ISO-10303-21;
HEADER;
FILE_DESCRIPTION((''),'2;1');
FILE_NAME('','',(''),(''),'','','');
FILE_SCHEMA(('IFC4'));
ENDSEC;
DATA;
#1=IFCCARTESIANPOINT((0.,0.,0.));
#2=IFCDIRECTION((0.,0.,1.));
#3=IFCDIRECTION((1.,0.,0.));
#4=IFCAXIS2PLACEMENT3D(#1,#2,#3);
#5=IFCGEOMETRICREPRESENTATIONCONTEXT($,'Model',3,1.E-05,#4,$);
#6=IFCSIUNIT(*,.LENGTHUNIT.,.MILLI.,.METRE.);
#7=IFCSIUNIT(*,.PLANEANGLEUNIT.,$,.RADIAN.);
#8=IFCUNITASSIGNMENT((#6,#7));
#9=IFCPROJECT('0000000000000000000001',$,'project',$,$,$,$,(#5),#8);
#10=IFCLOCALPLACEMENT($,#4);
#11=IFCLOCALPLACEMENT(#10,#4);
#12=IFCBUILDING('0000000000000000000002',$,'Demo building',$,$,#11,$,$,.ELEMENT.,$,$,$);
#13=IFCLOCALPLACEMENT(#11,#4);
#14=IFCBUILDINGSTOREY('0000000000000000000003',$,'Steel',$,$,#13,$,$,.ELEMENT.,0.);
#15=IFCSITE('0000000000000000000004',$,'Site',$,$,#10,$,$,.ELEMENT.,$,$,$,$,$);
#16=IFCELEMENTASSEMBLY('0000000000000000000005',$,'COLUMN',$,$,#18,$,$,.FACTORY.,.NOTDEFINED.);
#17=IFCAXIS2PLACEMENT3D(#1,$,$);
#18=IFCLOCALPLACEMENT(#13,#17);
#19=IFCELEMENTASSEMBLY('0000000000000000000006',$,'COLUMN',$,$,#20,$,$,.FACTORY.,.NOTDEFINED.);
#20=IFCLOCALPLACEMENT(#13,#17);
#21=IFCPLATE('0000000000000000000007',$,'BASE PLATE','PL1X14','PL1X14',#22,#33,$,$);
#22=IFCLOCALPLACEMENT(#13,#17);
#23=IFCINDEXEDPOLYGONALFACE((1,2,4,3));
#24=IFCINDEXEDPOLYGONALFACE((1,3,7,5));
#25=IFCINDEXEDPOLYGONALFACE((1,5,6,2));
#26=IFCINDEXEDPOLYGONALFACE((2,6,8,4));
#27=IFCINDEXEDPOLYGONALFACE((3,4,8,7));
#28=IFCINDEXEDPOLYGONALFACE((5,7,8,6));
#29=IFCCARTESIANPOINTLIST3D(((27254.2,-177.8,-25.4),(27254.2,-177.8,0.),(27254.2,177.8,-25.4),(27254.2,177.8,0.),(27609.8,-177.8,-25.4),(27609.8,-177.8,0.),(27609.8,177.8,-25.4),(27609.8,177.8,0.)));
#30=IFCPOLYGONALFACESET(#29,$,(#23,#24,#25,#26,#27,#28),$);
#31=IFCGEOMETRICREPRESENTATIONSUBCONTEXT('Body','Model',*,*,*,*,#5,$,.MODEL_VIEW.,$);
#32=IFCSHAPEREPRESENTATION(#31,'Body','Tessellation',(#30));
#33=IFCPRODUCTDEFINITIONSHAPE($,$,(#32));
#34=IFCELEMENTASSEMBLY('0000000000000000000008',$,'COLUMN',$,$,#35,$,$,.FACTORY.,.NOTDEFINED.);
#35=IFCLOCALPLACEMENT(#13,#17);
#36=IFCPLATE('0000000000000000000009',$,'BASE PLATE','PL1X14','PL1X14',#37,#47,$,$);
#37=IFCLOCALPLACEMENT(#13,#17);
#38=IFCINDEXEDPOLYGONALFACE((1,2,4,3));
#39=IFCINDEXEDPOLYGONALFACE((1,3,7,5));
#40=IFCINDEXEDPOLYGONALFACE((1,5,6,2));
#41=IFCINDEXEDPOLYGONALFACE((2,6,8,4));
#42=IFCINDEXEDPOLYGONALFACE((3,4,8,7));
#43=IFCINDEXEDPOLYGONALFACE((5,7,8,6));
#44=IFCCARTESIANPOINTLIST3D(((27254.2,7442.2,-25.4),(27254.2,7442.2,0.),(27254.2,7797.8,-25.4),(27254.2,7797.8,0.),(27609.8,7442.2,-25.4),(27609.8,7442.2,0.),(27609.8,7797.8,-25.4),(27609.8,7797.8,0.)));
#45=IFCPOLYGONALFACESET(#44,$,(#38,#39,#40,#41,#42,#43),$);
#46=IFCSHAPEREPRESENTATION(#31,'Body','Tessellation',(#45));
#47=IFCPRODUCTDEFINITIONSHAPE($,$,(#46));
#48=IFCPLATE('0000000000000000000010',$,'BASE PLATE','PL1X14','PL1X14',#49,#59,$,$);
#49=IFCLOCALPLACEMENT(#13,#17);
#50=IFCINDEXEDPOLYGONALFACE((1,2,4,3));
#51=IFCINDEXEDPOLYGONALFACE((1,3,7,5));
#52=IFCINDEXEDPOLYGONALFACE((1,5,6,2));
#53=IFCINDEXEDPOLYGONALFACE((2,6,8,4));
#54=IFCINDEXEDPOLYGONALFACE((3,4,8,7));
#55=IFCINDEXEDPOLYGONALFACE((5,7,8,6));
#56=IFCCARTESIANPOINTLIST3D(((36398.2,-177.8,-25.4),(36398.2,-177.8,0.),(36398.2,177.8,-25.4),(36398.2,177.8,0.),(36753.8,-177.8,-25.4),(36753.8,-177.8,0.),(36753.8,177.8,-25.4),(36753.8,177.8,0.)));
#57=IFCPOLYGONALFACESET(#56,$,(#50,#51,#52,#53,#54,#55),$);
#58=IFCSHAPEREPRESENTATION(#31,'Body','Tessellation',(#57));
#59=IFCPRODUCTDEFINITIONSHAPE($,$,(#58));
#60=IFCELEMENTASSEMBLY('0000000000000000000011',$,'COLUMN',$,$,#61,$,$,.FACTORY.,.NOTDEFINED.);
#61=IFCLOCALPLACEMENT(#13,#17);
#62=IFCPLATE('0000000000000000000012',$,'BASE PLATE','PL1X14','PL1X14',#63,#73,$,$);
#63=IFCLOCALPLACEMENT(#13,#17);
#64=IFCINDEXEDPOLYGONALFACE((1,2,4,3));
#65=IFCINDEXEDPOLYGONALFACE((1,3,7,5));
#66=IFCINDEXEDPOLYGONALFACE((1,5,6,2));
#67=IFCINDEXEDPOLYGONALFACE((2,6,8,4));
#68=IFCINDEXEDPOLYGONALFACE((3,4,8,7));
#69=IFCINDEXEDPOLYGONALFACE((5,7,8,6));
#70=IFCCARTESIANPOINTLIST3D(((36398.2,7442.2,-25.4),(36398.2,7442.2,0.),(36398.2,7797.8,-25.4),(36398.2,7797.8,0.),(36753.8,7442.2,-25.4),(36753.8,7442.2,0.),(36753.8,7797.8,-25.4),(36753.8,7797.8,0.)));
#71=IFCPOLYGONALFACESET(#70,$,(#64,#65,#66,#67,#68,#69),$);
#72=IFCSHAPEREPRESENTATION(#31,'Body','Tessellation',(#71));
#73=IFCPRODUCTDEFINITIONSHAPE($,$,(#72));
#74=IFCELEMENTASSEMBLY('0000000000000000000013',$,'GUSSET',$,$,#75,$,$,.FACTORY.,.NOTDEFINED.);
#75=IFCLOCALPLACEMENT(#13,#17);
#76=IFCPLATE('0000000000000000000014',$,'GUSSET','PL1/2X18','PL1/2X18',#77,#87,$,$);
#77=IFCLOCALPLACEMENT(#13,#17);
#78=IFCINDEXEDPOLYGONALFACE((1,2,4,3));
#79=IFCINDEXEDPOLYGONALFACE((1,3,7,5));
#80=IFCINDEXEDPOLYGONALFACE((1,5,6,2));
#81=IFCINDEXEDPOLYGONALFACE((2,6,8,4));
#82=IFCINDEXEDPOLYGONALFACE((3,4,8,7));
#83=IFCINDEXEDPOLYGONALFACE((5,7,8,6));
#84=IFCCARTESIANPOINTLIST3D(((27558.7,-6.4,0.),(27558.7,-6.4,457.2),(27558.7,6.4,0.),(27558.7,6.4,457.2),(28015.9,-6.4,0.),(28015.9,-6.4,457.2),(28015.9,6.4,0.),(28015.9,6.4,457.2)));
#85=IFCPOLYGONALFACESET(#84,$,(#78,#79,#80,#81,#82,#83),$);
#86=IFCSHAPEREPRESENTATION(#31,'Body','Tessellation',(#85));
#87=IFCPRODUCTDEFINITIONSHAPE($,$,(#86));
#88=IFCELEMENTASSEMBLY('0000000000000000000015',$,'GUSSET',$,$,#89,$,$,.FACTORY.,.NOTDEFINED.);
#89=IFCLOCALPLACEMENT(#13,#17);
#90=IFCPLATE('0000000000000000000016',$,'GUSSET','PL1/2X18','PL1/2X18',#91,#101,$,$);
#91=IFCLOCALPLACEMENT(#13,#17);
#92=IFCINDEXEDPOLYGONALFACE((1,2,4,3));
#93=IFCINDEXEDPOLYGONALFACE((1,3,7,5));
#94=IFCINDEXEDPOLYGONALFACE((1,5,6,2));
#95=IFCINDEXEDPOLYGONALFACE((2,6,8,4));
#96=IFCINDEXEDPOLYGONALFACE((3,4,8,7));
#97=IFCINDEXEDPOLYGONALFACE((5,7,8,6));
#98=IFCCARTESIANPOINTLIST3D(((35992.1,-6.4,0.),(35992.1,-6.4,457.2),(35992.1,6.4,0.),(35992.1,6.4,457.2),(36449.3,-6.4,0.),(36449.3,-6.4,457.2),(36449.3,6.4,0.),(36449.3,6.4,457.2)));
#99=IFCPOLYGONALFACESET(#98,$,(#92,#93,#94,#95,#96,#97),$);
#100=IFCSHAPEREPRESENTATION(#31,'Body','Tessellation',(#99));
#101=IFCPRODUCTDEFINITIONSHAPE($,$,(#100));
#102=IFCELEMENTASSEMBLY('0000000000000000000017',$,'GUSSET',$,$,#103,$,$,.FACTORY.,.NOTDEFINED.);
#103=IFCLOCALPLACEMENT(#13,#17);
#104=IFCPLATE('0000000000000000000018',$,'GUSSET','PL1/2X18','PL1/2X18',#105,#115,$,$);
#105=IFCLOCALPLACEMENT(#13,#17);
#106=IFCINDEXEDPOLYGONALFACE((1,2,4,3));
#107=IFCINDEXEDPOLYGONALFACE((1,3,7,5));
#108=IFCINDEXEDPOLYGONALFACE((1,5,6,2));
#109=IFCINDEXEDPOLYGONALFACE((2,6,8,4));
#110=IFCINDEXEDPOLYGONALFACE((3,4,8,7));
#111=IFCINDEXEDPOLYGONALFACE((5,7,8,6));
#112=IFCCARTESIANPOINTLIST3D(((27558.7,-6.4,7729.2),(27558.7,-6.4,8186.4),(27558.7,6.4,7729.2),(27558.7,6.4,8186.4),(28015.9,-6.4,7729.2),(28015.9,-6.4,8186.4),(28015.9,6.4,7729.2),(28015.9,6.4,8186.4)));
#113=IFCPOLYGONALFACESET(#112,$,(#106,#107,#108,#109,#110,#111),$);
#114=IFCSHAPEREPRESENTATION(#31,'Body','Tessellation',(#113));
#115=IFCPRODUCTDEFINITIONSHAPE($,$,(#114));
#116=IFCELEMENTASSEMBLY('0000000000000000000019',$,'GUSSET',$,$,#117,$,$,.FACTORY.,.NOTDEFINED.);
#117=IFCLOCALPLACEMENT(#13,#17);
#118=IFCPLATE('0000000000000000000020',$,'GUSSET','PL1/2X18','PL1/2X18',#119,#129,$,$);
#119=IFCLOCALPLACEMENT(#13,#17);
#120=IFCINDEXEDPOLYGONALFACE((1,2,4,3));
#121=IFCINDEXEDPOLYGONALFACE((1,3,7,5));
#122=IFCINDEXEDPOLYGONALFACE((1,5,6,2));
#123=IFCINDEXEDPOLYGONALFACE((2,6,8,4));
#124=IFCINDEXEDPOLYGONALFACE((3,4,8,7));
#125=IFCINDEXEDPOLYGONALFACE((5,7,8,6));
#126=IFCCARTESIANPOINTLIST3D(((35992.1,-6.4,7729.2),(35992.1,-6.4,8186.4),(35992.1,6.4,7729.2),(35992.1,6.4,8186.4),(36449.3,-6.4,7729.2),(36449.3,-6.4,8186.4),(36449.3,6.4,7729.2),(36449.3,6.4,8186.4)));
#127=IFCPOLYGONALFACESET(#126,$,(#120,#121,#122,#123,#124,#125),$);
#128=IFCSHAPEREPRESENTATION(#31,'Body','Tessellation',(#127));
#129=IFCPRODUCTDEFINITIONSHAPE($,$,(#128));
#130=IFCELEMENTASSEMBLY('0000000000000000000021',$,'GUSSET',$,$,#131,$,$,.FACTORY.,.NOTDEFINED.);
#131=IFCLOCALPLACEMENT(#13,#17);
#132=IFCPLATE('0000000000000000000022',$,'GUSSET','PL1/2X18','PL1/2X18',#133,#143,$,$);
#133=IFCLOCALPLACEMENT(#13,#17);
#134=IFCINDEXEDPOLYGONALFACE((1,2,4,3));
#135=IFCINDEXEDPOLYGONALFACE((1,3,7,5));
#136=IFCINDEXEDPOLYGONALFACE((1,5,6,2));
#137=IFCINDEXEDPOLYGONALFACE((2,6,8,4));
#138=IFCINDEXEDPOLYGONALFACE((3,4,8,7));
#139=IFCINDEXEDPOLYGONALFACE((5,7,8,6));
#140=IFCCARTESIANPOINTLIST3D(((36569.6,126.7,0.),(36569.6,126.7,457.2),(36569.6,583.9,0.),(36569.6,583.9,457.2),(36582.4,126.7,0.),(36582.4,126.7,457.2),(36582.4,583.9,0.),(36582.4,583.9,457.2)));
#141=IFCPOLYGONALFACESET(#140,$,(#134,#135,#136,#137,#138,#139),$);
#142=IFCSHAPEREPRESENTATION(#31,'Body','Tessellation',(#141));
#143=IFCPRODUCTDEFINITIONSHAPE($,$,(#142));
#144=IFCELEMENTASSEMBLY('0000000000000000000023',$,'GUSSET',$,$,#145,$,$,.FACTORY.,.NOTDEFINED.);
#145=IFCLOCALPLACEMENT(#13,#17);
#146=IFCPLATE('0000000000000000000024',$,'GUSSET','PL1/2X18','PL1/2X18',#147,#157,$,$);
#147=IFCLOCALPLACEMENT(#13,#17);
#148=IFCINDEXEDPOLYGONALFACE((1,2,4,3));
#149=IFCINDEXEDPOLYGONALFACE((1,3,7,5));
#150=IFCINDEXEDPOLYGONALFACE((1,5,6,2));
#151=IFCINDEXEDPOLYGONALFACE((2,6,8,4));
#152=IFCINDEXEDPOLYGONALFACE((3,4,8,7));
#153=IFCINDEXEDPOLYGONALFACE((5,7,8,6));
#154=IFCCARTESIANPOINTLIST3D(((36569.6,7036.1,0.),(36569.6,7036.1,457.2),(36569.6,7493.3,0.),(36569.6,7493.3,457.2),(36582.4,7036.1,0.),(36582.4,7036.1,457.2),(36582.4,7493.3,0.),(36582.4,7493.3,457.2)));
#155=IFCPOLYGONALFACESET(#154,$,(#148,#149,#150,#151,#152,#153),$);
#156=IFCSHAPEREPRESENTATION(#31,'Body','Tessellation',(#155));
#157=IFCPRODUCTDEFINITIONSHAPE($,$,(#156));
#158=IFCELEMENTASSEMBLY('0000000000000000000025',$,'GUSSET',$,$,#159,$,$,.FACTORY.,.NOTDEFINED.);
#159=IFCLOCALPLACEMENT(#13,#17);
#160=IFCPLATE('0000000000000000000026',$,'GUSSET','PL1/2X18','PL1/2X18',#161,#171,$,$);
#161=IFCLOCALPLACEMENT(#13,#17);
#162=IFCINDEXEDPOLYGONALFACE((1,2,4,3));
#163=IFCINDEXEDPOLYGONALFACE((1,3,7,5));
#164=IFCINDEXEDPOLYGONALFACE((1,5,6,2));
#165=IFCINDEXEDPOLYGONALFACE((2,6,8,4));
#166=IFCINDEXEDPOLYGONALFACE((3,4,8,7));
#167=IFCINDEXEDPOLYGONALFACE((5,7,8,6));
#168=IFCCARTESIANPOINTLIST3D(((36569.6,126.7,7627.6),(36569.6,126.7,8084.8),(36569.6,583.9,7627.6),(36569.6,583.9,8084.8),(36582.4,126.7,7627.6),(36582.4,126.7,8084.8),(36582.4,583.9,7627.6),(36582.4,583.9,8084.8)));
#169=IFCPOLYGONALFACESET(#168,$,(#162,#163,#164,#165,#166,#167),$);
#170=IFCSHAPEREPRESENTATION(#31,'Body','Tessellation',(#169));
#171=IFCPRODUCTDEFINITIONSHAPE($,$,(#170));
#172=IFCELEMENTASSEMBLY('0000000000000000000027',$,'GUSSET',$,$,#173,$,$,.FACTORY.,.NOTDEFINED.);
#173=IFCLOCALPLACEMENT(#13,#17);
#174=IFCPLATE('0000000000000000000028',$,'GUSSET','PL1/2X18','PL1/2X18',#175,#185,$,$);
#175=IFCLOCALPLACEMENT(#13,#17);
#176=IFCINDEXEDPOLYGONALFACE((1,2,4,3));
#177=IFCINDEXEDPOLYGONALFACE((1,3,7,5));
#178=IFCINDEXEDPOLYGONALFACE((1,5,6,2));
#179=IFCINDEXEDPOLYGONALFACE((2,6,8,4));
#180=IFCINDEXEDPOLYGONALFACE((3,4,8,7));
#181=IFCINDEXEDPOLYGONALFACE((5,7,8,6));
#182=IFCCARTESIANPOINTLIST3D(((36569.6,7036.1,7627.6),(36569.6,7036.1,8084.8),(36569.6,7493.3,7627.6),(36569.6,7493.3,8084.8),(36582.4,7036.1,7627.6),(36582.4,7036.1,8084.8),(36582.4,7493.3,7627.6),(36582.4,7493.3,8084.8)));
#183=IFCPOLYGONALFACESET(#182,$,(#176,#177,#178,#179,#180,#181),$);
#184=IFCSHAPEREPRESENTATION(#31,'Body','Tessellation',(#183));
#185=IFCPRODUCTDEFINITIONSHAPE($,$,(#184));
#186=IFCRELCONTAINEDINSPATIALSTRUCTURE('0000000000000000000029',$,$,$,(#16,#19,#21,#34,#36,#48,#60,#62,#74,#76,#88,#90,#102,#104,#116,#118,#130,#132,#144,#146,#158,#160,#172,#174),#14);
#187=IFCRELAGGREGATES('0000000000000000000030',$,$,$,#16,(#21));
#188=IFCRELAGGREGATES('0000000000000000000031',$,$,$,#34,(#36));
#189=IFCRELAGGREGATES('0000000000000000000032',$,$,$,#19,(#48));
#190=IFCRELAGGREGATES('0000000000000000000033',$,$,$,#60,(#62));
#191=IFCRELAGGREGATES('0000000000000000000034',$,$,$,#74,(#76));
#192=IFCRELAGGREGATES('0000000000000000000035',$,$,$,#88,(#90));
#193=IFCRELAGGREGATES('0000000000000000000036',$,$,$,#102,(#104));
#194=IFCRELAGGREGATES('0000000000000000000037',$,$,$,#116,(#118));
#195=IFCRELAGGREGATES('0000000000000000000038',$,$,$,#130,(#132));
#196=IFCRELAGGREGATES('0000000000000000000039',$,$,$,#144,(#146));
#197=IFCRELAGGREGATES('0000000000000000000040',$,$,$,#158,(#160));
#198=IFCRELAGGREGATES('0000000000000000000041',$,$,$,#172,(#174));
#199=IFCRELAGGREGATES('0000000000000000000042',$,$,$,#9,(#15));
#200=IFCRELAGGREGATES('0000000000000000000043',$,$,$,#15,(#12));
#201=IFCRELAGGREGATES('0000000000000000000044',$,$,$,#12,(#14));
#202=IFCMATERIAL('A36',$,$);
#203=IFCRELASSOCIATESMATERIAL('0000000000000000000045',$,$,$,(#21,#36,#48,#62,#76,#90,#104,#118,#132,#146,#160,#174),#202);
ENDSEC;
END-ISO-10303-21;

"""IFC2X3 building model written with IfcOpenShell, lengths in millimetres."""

from ifc_helpers import new_model, si_unit, frame, frame_2d, origin, origin_with_axes, place, context, subcontext, project, spatial, rectangle, extrude, material, element, aggregate, save


model = new_model("IFC2X3")

# Units and contexts
model_context = context("Model", 3, precision=1e-05, world=origin_with_axes())
body_context = subcontext(model_context, "Body", "Model", "MODEL_VIEW")
ifc_project = project(units=[si_unit("LENGTHUNIT", "METRE", prefix="MILLI"), si_unit("PLANEANGLEUNIT", "RADIAN")], contexts=[model_context])

# Site, building, storey
site_placement = place(None, origin_with_axes())
site = spatial("IfcSite", under=ifc_project, at=site_placement, Name="Site", CompositionType="ELEMENT")
building_placement = place(site_placement, origin_with_axes())
building = spatial("IfcBuilding", under=site, at=building_placement, Name="Demo building", CompositionType="ELEMENT")
placement = place(building_placement, origin_with_axes())
storey = spatial("IfcBuildingStorey", under=building, at=placement, Name="Steel", CompositionType="ELEMENT", Elevation=0.0)

# Element assemblies
assembly_1 = element("IfcElementAssembly", 1, at=placement, inside=storey, Name="COLUMN", AssemblyPlace="FACTORY", PredefinedType="NOTDEFINED")
assembly_2 = element("IfcElementAssembly", 2, at=placement, inside=storey, Name="COLUMN", AssemblyPlace="FACTORY", PredefinedType="NOTDEFINED")

# Plate
ifc_material_1 = material(Name="A36")
plate_1_placement = place(placement, frame((27254.2, -177.8, -25.4), z_axis=(0.0, 0.0, 1.0), x_axis=(1.0, 0.0, 0.0)))
plate_1 = element("IfcPlate", 3, at=plate_1_placement, inside=storey, material=ifc_material_1, Name="BASE PLATE", Description="PL1X14", ObjectType="PL1X14", context=body_context, shape_type="SweptSolid", body=[
    extrude(rectangle(XDim=355.6, YDim=355.6, at=frame_2d((177.8, 177.8))), origin(), (0.0, 0.0, 1.0), 25.4),
])
aggregate(assembly_1, [plate_1])

# Element assembly, plate
assembly_3 = element("IfcElementAssembly", 4, at=placement, inside=storey, Name="COLUMN", AssemblyPlace="FACTORY", PredefinedType="NOTDEFINED")
plate_2_placement = place(placement, frame((27254.2, 7442.2, -25.4), z_axis=(0.0, 0.0, 1.0), x_axis=(1.0, 0.0, 0.0)))
plate_2 = element("IfcPlate", 5, at=plate_2_placement, inside=storey, material=ifc_material_1, Name="BASE PLATE", Description="PL1X14", ObjectType="PL1X14", context=body_context, shape_type="SweptSolid", body=[
    extrude(rectangle(XDim=355.6, YDim=355.6, at=frame_2d((177.8, 177.8))), origin(), (0.0, 0.0, 1.0), 25.4),
])
aggregate(assembly_3, [plate_2])

# Plate
plate_3_placement = place(placement, frame((36398.2, -177.8, -25.4), z_axis=(0.0, 0.0, 1.0), x_axis=(1.0, 0.0, 0.0)))
plate_3 = element("IfcPlate", 6, at=plate_3_placement, inside=storey, material=ifc_material_1, Name="BASE PLATE", Description="PL1X14", ObjectType="PL1X14", context=body_context, shape_type="SweptSolid", body=[
    extrude(rectangle(XDim=355.6, YDim=355.6, at=frame_2d((177.8, 177.8))), origin(), (0.0, 0.0, 1.0), 25.4),
])
aggregate(assembly_2, [plate_3])

# Element assemblies, plates
assembly_4 = element("IfcElementAssembly", 7, at=placement, inside=storey, Name="COLUMN", AssemblyPlace="FACTORY", PredefinedType="NOTDEFINED")
plate_4_placement = place(placement, frame((36398.2, 7442.2, -25.4), z_axis=(0.0, 0.0, 1.0), x_axis=(1.0, 0.0, 0.0)))
plate_4 = element("IfcPlate", 8, at=plate_4_placement, inside=storey, material=ifc_material_1, Name="BASE PLATE", Description="PL1X14", ObjectType="PL1X14", context=body_context, shape_type="SweptSolid", body=[
    extrude(rectangle(XDim=355.6, YDim=355.6, at=frame_2d((177.8, 177.8))), origin(), (0.0, 0.0, 1.0), 25.4),
])
aggregate(assembly_4, [plate_4])
assembly_5 = element("IfcElementAssembly", 9, at=placement, inside=storey, Name="GUSSET", AssemblyPlace="FACTORY", PredefinedType="NOTDEFINED")
plate_5_placement = place(placement, frame((27558.7, 6.3, 0.0), z_axis=(0.0, -1.0, 0.0), x_axis=(1.0, 0.0, 0.0)))
plate_5 = element("IfcPlate", 10, at=plate_5_placement, inside=storey, material=ifc_material_1, Name="GUSSET", Description="PL1/2X18", ObjectType="PL1/2X18", context=body_context, shape_type="SweptSolid", body=[
    extrude(rectangle(XDim=457.2, YDim=457.2, at=frame_2d((228.6, 228.6))), origin(), (0.0, 0.0, 1.0), 12.7),
])
aggregate(assembly_5, [plate_5])
assembly_6 = element("IfcElementAssembly", 11, at=placement, inside=storey, Name="GUSSET", AssemblyPlace="FACTORY", PredefinedType="NOTDEFINED")
plate_6_placement = place(placement, frame((35992.1, 6.3, 0.0), z_axis=(0.0, -1.0, 0.0), x_axis=(1.0, 0.0, 0.0)))
plate_6 = element("IfcPlate", 12, at=plate_6_placement, inside=storey, material=ifc_material_1, Name="GUSSET", Description="PL1/2X18", ObjectType="PL1/2X18", context=body_context, shape_type="SweptSolid", body=[
    extrude(rectangle(XDim=457.2, YDim=457.2, at=frame_2d((228.6, 228.6))), origin(), (0.0, 0.0, 1.0), 12.7),
])
aggregate(assembly_6, [plate_6])
assembly_7 = element("IfcElementAssembly", 13, at=placement, inside=storey, Name="GUSSET", AssemblyPlace="FACTORY", PredefinedType="NOTDEFINED")
plate_7_placement = place(placement, frame((27558.7, 6.3, 7729.2), z_axis=(0.0, -1.0, 0.0), x_axis=(1.0, 0.0, 0.0)))
plate_7 = element("IfcPlate", 14, at=plate_7_placement, inside=storey, material=ifc_material_1, Name="GUSSET", Description="PL1/2X18", ObjectType="PL1/2X18", context=body_context, shape_type="SweptSolid", body=[
    extrude(rectangle(XDim=457.2, YDim=457.2, at=frame_2d((228.6, 228.6))), origin(), (0.0, 0.0, 1.0), 12.7),
])
aggregate(assembly_7, [plate_7])
assembly_8 = element("IfcElementAssembly", 15, at=placement, inside=storey, Name="GUSSET", AssemblyPlace="FACTORY", PredefinedType="NOTDEFINED")
plate_8_placement = place(placement, frame((35992.1, 6.3, 7729.2), z_axis=(0.0, -1.0, 0.0), x_axis=(1.0, 0.0, 0.0)))
plate_8 = element("IfcPlate", 16, at=plate_8_placement, inside=storey, material=ifc_material_1, Name="GUSSET", Description="PL1/2X18", ObjectType="PL1/2X18", context=body_context, shape_type="SweptSolid", body=[
    extrude(rectangle(XDim=457.2, YDim=457.2, at=frame_2d((228.6, 228.6))), origin(), (0.0, 0.0, 1.0), 12.7),
])
aggregate(assembly_8, [plate_8])
assembly_9 = element("IfcElementAssembly", 17, at=placement, inside=storey, Name="GUSSET", AssemblyPlace="FACTORY", PredefinedType="NOTDEFINED")
plate_9_placement = place(placement, frame((36569.7, 126.7, 0.0), z_axis=(1.0, 0.0, 0.0), x_axis=(0.0, 1.0, 0.0)))
plate_9 = element("IfcPlate", 18, at=plate_9_placement, inside=storey, material=ifc_material_1, Name="GUSSET", Description="PL1/2X18", ObjectType="PL1/2X18", context=body_context, shape_type="SweptSolid", body=[
    extrude(rectangle(XDim=457.2, YDim=457.2, at=frame_2d((228.6, 228.6))), origin(), (0.0, 0.0, 1.0), 12.7),
])
aggregate(assembly_9, [plate_9])
assembly_10 = element("IfcElementAssembly", 19, at=placement, inside=storey, Name="GUSSET", AssemblyPlace="FACTORY", PredefinedType="NOTDEFINED")
plate_10_placement = place(placement, frame((36569.7, 7036.1, 0.0), z_axis=(1.0, 0.0, 0.0), x_axis=(0.0, 1.0, 0.0)))
plate_10 = element("IfcPlate", 20, at=plate_10_placement, inside=storey, material=ifc_material_1, Name="GUSSET", Description="PL1/2X18", ObjectType="PL1/2X18", context=body_context, shape_type="SweptSolid", body=[
    extrude(rectangle(XDim=457.2, YDim=457.2, at=frame_2d((228.6, 228.6))), origin(), (0.0, 0.0, 1.0), 12.7),
])
aggregate(assembly_10, [plate_10])
assembly_11 = element("IfcElementAssembly", 21, at=placement, inside=storey, Name="GUSSET", AssemblyPlace="FACTORY", PredefinedType="NOTDEFINED")
plate_11_placement = place(placement, frame((36569.7, 126.7, 7627.6), z_axis=(1.0, 0.0, 0.0), x_axis=(0.0, 1.0, 0.0)))
plate_11 = element("IfcPlate", 22, at=plate_11_placement, inside=storey, material=ifc_material_1, Name="GUSSET", Description="PL1/2X18", ObjectType="PL1/2X18", context=body_context, shape_type="SweptSolid", body=[
    extrude(rectangle(XDim=457.2, YDim=457.2, at=frame_2d((228.6, 228.6))), origin(), (0.0, 0.0, 1.0), 12.7),
])
aggregate(assembly_11, [plate_11])
assembly_12 = element("IfcElementAssembly", 23, at=placement, inside=storey, Name="GUSSET", AssemblyPlace="FACTORY", PredefinedType="NOTDEFINED")
plate_12_placement = place(placement, frame((36569.7, 7036.1, 7627.6), z_axis=(1.0, 0.0, 0.0), x_axis=(0.0, 1.0, 0.0)))
plate_12 = element("IfcPlate", 24, at=plate_12_placement, inside=storey, material=ifc_material_1, Name="GUSSET", Description="PL1/2X18", ObjectType="PL1/2X18", context=body_context, shape_type="SweptSolid", body=[
    extrude(rectangle(XDim=457.2, YDim=457.2, at=frame_2d((228.6, 228.6))), origin(), (0.0, 0.0, 1.0), 12.7),
])
aggregate(assembly_12, [plate_12])

save(model, "model.ifc")
